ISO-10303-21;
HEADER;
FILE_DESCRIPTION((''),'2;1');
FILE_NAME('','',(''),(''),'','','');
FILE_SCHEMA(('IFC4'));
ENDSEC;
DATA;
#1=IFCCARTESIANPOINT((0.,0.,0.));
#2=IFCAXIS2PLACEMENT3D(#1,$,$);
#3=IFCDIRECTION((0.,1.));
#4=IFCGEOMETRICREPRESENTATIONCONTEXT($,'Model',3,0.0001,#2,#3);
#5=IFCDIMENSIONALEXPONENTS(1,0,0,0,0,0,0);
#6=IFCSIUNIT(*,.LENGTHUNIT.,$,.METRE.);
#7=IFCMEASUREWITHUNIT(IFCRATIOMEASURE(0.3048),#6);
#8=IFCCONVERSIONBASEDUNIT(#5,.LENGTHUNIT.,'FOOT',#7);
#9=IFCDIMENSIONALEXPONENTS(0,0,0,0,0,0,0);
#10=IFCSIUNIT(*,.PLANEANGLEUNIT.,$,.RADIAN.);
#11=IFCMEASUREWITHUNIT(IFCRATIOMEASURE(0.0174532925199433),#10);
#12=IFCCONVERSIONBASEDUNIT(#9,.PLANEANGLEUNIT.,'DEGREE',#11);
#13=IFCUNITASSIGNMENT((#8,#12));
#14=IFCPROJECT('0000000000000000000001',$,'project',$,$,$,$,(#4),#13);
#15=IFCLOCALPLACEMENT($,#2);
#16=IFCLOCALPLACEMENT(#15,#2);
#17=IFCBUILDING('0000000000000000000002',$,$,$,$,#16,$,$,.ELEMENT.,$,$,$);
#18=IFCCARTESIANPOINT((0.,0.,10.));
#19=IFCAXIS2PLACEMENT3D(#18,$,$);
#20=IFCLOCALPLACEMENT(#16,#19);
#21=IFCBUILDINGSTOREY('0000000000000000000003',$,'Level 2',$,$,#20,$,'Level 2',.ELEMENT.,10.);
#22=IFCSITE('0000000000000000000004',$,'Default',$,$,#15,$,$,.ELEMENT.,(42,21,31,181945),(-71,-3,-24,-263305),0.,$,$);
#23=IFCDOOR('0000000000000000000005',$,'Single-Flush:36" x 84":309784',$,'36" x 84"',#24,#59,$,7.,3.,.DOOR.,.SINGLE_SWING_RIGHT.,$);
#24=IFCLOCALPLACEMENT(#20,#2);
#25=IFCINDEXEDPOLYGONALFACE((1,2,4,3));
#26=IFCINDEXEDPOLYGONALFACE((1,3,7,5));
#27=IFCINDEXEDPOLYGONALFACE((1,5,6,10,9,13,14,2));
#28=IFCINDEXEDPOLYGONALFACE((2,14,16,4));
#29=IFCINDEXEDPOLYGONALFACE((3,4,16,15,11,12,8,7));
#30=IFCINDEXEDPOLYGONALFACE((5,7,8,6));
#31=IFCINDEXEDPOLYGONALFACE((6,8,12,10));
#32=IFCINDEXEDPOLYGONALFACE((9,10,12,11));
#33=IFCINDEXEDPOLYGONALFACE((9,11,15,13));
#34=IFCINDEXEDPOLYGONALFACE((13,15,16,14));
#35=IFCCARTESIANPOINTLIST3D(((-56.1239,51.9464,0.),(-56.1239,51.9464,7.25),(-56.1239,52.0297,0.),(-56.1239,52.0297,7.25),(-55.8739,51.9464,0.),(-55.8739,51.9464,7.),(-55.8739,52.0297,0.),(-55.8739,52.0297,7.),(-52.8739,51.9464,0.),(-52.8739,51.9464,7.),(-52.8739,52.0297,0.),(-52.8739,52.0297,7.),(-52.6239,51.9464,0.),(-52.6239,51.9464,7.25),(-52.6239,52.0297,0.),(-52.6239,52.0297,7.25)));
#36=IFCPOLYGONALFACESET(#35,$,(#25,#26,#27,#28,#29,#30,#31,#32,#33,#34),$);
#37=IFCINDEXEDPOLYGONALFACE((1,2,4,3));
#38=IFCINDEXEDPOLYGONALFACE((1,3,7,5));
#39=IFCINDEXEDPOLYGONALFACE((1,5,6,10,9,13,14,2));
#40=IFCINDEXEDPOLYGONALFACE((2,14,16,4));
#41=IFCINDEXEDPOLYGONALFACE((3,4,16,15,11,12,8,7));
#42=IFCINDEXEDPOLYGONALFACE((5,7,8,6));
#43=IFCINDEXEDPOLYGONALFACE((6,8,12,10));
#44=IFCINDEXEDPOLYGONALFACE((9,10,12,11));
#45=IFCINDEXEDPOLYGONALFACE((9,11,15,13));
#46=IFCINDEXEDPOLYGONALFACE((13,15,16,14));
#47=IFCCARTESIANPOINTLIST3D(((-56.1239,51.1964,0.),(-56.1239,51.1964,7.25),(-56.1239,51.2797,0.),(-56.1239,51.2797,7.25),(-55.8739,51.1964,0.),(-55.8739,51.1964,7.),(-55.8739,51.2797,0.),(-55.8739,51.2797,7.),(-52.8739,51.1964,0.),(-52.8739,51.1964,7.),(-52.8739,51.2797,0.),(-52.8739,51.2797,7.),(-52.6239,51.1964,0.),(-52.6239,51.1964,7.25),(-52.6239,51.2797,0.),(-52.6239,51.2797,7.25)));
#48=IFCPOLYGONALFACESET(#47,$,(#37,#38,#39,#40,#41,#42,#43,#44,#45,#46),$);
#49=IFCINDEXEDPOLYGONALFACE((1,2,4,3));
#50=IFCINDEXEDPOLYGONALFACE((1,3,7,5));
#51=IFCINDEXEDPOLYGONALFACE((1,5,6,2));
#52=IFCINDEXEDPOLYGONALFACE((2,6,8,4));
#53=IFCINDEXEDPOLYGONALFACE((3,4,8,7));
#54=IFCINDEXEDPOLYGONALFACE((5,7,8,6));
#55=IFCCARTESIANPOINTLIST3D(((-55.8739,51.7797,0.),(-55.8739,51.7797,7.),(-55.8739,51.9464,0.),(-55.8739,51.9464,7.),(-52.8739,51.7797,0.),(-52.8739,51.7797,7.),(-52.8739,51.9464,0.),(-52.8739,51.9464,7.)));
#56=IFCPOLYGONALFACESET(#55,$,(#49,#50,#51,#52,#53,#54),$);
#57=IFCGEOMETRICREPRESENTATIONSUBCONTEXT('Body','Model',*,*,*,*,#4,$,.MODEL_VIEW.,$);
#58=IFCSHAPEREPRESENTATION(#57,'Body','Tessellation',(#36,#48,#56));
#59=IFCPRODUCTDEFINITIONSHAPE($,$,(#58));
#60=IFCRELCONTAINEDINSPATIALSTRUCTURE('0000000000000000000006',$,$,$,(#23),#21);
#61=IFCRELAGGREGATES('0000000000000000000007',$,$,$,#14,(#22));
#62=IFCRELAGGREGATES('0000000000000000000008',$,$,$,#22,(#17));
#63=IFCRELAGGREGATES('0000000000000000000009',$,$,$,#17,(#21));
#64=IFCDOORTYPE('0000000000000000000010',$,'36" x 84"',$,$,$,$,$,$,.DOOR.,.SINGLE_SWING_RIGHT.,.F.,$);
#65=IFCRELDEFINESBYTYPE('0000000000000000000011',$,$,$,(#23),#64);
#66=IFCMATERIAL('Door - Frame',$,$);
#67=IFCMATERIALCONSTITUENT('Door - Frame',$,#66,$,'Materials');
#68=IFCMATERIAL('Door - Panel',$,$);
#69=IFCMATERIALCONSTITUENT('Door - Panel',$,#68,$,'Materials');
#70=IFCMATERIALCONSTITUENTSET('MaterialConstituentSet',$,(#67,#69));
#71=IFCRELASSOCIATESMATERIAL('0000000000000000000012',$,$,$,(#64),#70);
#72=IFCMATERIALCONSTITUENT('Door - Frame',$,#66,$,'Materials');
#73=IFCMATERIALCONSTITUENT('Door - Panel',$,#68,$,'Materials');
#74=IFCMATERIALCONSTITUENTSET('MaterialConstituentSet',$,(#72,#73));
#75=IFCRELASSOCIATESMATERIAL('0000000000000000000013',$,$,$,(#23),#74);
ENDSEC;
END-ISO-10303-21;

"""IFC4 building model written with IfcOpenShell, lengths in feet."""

from ifc_helpers import new_model, entity, si_unit, converted_unit, direction, frame, frame_2d, origin, place, context, subcontext, project, spatial, polyline, rectangle, outline, extrude, source, transform, mapped, material, constituent, constituent_set, type_object, type_shapes, element, save


model = new_model("IFC4")

# Units and contexts
model_context = context("Model", 3, precision=0.0001, world=origin(), true_north=direction((0.0, 1.0)))
body_context = subcontext(model_context, "Body", "Model", "MODEL_VIEW")
ifc_project = project(units=[converted_unit("LENGTHUNIT", "FOOT", entity("IfcRatioMeasure", 0.3048), si_unit("LENGTHUNIT", "METRE"), dimensions=[1, 0, 0, 0, 0, 0, 0]), converted_unit("PLANEANGLEUNIT", "DEGREE", entity("IfcRatioMeasure", 0.0174532925199433), si_unit("PLANEANGLEUNIT", "RADIAN"), dimensions=[0, 0, 0, 0, 0, 0, 0])], contexts=[model_context])

# Site, building, storey
site_placement = place(None, origin())
site = spatial("IfcSite", under=ifc_project, at=site_placement, Name="Default", CompositionType="ELEMENT", RefLatitude=(42, 21, 31, 181945), RefLongitude=(-71, -3, -24, -263305), RefElevation=0.0)
building_placement = place(site_placement, origin())
building = spatial("IfcBuilding", under=site, at=building_placement, CompositionType="ELEMENT")
storey_placement = place(building_placement, frame((0.0, 0.0, 10.0)))
storey = spatial("IfcBuildingStorey", under=building, at=storey_placement, Name="Level 2", LongName="Level 2", CompositionType="ELEMENT", Elevation=10.0)

# Shared definitions
placement_1 = place(storey_placement, frame((-69.2906, 51.6131, 0.0)))

# Door
ifc_material_1 = material(Name="Door - Frame")
ifc_constituent_1 = constituent(ifc_material_1, Name="Door - Frame", Category="Materials")
ifc_material_2 = material(Name="Door - Panel")
ifc_constituent_2 = constituent(ifc_material_2, Name="Door - Panel", Category="Materials")
ifc_constituent_set_1 = constituent_set(constituents=[ifc_constituent_1, ifc_constituent_2], Name="MaterialConstituentSet")
ifc_constituent_3 = constituent(ifc_material_1, Name="Door - Frame", Category="Materials")
ifc_constituent_4 = constituent(ifc_material_2, Name="Door - Panel", Category="Materials")
ifc_constituent_set_2 = constituent_set(constituents=[ifc_constituent_3, ifc_constituent_4], Name="MaterialConstituentSet")
door_type = type_object("IfcDoorType", Name="36\" x 84\"", OperationType="SINGLE_SWING_RIGHT", ParameterTakesPrecedence=False, PredefinedType="DOOR", material=ifc_constituent_set_2)
shared_shape = source(origin(), body_context, "Body", "SweptSolid", [
    extrude(outline(polyline([(-1.75, -3.6875), (1.75, -3.6875), (1.75, 3.5625), (1.5, 3.5625), (1.5, -3.4375), (-1.5, -3.4375), (-1.5, 3.5625), (-1.75, 3.5625), (-1.75, -3.6875)])), frame((1.5, 0.6667, 3.5625), z_axis=(0.0, 1.0, 0.0), x_axis=(1.0, 0.0, 0.0)), (0.0, 0.0, 1.0), 0.0833),
    extrude(outline(polyline([(-3.6875, -1.75), (3.5625, -1.75), (3.5625, -1.5), (-3.4375, -1.5), (-3.4375, 1.5), (3.5625, 1.5), (3.5625, 1.75), (-3.6875, 1.75), (-3.6875, -1.75)])), frame((1.5, -0.0833, 3.5625), z_axis=(0.0, 1.0, 0.0), x_axis=(0.0, 0.0, -1.0)), (0.0, 0.0, 1.0), 0.0833),
    extrude(rectangle(XDim=0.1667, YDim=3.0, at=frame_2d((0.0, 0.0), x_axis=(1.0, 0.0))), frame((1.5, 0.5833, 0.0), z_axis=(0.0, 0.0, 1.0), x_axis=(0.0, 1.0, 0.0)), (0.0, 0.0, 1.0), 7.0),
])
type_shapes(door_type, [shared_shape])
placement_2 = place(placement_1, frame((13.4167, -0.3333, 0.0)))
door_placement = place(placement_2, origin())
element("IfcDoor", 1, at=door_placement, inside=storey, type_object=door_type, material=ifc_constituent_set_1, Name="Single-Flush:36\" x 84\":309784", ObjectType="36\" x 84\"", OperationType="SINGLE_SWING_RIGHT", OverallHeight=7.0, OverallWidth=3.0, PredefinedType="DOOR", context=body_context, shape_type="MappedRepresentation", body=[
    mapped(shared_shape, transform((0.0, 0.0, 0.0), scale=1.0)),
])

save(model, "model.ifc")
